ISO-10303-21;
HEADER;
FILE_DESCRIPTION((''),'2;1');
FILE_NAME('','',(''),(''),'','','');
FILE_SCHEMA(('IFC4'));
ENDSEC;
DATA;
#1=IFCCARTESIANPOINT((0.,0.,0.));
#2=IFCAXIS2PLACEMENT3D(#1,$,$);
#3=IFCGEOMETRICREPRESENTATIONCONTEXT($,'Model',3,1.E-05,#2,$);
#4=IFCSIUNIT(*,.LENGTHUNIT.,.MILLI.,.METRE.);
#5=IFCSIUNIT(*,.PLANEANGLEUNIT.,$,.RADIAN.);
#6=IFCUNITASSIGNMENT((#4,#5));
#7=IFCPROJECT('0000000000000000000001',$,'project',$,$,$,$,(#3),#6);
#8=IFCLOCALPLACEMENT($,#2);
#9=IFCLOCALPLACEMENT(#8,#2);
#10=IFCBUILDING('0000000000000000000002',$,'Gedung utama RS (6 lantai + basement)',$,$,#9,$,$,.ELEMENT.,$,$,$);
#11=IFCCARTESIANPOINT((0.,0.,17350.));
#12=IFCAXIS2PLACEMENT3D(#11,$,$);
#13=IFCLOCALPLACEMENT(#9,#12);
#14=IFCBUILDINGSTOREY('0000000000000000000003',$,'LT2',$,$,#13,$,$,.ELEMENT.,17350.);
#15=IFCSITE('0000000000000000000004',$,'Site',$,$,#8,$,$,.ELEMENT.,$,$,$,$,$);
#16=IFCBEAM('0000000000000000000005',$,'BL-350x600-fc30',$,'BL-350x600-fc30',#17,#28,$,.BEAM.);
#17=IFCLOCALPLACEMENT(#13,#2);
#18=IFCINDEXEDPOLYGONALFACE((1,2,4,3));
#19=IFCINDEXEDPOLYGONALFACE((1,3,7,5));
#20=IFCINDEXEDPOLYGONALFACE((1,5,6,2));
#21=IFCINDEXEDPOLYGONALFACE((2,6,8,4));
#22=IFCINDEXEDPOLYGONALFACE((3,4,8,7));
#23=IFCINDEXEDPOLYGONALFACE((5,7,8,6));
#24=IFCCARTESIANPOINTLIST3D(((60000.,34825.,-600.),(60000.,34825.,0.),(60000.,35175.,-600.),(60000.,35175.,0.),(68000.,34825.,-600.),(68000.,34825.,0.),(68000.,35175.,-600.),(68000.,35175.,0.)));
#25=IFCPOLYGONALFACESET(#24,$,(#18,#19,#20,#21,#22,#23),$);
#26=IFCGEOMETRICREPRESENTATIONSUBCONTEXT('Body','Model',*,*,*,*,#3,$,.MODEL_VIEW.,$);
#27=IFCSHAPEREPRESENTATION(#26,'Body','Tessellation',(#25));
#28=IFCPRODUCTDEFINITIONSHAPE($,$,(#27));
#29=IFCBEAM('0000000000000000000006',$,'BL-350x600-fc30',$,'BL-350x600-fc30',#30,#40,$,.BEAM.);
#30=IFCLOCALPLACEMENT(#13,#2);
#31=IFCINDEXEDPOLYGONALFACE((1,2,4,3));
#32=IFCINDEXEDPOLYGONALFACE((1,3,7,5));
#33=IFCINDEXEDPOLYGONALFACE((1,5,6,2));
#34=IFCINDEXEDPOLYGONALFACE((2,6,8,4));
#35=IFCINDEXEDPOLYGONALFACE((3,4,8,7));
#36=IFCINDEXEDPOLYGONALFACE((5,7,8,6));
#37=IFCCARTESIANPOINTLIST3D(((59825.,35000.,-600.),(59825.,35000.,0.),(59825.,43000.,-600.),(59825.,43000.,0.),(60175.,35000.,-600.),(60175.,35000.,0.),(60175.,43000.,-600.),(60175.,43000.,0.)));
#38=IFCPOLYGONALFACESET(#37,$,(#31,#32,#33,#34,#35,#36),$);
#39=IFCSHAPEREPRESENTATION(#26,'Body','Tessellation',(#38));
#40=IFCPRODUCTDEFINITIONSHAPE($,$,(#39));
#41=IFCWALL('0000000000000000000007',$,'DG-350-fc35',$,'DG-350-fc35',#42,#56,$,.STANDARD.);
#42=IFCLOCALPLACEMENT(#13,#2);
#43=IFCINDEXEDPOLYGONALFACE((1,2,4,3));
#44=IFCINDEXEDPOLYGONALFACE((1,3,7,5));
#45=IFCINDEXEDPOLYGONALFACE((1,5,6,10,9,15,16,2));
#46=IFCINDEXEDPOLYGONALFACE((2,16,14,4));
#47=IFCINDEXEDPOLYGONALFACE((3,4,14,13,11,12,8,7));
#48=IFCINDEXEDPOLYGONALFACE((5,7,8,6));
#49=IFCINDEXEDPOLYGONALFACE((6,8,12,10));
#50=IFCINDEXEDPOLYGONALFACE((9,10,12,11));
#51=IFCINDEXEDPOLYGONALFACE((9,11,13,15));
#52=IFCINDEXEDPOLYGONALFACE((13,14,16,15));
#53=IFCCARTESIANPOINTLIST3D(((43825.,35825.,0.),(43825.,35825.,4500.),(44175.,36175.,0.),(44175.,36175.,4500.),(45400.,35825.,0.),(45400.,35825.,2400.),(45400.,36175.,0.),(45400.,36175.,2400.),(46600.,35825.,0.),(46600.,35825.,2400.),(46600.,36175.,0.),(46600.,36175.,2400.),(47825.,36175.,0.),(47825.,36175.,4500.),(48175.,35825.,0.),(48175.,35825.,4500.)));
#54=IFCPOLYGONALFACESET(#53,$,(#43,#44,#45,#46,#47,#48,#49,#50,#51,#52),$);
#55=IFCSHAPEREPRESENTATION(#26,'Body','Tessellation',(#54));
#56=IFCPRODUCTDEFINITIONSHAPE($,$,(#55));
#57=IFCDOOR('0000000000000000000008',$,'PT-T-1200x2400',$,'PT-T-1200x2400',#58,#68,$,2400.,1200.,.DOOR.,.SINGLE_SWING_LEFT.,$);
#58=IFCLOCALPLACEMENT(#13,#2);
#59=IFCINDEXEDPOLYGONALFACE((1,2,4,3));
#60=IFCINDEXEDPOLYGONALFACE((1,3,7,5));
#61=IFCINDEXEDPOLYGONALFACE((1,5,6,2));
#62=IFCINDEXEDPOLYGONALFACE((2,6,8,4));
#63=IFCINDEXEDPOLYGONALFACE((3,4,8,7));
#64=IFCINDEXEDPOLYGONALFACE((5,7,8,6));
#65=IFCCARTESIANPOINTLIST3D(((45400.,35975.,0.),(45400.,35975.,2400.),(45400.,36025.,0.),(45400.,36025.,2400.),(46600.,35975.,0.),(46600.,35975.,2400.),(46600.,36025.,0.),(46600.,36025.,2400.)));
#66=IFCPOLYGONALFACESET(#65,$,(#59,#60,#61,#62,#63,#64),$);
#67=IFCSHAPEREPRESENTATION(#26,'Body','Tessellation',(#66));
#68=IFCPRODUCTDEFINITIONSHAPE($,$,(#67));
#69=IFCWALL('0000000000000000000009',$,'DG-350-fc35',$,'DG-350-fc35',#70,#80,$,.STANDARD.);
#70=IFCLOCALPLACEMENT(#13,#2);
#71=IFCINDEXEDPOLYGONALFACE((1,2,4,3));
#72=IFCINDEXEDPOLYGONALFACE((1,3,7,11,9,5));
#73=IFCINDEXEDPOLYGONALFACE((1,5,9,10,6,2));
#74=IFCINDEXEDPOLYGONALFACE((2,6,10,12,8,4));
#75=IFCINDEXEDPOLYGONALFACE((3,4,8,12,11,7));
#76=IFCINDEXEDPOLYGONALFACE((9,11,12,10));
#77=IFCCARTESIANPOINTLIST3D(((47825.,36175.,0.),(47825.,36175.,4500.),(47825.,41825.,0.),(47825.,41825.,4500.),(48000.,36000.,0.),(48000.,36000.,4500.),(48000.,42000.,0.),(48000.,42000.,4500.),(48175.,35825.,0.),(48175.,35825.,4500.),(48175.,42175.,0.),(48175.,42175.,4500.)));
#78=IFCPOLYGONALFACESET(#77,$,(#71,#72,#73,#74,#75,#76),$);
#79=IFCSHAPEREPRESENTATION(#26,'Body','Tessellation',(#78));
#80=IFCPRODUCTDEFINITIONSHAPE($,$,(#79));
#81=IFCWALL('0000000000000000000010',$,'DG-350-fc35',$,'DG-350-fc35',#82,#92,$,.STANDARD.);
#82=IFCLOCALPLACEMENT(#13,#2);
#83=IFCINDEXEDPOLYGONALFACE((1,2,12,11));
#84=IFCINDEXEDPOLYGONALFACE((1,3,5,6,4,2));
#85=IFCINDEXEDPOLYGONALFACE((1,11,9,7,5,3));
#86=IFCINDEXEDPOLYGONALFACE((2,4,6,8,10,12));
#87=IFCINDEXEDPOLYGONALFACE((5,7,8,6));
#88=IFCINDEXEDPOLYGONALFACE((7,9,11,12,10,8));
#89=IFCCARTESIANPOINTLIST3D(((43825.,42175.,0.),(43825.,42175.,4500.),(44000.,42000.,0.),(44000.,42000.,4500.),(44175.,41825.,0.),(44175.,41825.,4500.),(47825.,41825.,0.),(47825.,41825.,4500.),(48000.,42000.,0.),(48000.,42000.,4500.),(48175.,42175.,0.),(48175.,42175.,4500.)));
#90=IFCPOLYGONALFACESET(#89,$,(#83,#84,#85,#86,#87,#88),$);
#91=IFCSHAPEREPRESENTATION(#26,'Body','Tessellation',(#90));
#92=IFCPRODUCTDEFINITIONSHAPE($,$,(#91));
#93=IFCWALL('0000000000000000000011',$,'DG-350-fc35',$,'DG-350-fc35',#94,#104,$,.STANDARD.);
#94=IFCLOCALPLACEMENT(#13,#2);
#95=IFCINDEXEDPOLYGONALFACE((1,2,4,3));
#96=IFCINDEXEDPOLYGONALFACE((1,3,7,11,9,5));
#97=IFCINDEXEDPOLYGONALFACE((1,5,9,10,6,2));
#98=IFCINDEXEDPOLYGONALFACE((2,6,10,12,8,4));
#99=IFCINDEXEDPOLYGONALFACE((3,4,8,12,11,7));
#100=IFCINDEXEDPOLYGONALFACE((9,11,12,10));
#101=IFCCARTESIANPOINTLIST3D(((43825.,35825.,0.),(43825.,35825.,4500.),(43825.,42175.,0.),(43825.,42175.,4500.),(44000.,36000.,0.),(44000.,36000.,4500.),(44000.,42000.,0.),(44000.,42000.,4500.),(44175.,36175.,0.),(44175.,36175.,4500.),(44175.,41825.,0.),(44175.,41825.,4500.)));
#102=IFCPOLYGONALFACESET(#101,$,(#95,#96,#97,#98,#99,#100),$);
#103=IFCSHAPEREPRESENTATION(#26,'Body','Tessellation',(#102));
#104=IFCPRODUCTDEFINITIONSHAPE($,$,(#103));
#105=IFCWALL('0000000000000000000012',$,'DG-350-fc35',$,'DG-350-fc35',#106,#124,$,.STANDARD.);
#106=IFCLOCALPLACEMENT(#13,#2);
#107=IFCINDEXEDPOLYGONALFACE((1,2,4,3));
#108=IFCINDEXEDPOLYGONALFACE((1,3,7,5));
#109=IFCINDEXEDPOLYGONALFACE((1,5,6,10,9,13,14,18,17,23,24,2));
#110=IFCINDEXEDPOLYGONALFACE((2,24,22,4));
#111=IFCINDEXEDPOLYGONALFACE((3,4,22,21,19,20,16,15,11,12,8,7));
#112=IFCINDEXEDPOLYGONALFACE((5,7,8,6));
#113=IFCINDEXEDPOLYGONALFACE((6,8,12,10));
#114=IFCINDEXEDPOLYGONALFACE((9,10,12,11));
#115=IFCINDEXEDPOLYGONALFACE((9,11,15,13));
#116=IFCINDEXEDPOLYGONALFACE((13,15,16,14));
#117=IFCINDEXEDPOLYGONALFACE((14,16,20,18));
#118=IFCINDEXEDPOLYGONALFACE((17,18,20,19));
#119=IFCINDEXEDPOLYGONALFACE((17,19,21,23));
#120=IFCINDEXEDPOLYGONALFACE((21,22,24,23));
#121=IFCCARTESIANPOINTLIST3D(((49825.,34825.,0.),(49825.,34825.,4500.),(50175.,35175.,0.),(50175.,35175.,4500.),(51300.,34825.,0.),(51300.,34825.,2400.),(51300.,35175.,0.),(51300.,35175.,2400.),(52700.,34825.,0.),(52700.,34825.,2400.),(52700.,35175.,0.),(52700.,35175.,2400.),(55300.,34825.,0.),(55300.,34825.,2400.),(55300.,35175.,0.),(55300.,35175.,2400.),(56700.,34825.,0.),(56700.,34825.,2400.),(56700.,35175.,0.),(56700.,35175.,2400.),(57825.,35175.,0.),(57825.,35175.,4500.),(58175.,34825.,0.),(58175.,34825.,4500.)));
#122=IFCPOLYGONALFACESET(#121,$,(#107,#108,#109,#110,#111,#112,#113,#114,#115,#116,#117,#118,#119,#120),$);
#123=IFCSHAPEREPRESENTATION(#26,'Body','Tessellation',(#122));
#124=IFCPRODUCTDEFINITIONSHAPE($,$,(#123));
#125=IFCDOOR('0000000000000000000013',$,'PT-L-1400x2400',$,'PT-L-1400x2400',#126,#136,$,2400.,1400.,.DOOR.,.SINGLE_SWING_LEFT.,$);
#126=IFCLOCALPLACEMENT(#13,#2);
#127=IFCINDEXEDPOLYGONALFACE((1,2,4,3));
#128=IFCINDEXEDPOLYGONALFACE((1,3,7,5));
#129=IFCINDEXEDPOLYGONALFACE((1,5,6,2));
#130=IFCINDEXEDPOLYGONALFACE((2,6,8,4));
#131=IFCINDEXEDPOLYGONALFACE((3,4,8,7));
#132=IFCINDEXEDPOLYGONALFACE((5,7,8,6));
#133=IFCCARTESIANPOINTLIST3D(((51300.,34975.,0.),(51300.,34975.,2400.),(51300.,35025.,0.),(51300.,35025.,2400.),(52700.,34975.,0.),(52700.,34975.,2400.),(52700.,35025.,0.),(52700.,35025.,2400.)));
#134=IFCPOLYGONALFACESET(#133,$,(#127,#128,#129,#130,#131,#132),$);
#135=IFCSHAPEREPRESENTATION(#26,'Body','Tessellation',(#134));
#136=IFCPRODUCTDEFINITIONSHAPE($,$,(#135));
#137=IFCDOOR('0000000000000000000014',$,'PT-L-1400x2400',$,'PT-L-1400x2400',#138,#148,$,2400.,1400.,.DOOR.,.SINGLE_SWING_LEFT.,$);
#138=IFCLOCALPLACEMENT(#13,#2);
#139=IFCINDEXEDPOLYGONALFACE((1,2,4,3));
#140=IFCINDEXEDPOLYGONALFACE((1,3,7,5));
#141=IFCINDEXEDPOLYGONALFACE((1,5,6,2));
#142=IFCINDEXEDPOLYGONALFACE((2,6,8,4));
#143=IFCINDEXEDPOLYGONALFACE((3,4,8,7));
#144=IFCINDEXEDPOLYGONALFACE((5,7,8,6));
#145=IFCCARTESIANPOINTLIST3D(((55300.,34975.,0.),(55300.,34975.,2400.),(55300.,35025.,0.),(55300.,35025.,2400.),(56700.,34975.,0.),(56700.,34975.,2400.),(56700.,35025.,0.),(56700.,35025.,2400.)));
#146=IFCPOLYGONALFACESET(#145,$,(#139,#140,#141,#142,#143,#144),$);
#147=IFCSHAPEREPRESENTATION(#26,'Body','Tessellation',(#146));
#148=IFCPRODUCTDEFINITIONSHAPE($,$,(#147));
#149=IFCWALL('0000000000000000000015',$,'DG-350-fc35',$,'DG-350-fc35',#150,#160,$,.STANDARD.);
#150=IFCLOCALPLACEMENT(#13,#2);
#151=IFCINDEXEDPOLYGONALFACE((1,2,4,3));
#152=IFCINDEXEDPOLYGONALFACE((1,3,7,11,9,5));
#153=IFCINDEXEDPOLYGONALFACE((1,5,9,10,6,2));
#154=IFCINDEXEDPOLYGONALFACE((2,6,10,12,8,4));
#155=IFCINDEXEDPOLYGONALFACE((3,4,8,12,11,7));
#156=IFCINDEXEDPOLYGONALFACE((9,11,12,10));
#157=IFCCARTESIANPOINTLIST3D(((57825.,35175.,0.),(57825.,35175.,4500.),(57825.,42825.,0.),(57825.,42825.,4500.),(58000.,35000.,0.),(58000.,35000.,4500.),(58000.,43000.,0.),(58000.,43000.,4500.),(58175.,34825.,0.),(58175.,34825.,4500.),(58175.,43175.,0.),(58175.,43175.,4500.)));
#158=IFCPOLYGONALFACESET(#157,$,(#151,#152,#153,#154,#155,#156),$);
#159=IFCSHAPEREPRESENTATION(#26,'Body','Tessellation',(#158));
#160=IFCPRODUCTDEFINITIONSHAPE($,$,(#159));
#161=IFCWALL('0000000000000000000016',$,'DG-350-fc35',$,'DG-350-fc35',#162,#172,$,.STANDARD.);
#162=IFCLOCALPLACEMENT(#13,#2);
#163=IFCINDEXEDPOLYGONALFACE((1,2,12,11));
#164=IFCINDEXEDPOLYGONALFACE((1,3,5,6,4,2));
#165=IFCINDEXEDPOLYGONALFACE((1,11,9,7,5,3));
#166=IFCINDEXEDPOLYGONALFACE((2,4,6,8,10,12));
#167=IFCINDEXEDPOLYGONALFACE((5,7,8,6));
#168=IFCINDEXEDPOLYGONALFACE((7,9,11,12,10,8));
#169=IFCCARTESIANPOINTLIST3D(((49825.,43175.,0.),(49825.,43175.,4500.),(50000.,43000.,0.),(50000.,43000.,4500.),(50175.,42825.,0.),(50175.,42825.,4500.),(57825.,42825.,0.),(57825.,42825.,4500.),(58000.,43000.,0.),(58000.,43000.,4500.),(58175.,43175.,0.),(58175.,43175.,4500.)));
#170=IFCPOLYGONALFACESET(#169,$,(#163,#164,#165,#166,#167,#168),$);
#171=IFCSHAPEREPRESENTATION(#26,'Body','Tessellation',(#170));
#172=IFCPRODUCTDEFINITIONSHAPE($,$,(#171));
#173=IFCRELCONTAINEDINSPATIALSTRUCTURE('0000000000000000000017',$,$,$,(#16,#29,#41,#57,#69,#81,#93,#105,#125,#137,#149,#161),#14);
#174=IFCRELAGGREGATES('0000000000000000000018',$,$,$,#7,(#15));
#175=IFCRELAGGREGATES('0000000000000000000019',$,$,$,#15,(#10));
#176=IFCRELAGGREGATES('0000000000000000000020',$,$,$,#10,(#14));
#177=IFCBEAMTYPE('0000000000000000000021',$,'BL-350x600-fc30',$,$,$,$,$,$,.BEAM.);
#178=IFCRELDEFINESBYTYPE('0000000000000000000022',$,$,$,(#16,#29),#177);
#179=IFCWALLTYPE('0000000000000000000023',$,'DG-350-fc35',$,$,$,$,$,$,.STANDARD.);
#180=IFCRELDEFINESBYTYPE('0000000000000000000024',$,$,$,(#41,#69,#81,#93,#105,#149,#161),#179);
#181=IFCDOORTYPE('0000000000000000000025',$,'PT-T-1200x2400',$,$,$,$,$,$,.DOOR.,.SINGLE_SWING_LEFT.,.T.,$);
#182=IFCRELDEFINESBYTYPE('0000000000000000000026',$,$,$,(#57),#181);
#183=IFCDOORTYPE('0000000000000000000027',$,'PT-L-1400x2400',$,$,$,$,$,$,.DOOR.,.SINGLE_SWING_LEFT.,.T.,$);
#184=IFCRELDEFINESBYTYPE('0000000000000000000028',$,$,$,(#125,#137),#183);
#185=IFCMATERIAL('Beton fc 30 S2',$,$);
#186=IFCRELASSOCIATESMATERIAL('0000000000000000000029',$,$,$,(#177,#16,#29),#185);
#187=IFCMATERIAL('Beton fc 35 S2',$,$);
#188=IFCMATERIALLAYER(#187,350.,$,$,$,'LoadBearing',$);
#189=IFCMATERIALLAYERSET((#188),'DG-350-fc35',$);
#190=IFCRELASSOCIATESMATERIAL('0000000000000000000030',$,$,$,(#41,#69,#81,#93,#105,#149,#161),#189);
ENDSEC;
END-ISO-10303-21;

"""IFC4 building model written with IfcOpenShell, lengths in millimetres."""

from ifc_helpers import new_model, si_unit, frame, frame_2d, origin, origin_2d, place, context, subcontext, project, spatial, polyline, rectangle, outline, extrude, material, layer, layer_set, layer_usage, material_profile, profile_set, profile_usage, type_object, element, fill, save


model = new_model("IFC4")

# Units and contexts
model_context = context("Model", 3, precision=1e-05, world=origin())
body_context = subcontext(model_context, "Body", "Model", "MODEL_VIEW")
ifc_project = project(units=[si_unit("LENGTHUNIT", "METRE", prefix="MILLI"), si_unit("PLANEANGLEUNIT", "RADIAN")], contexts=[model_context])

# Site, building, storey
site_placement = place(None, origin())
site = spatial("IfcSite", under=ifc_project, at=site_placement, Name="Site", CompositionType="ELEMENT")
building_placement = place(site_placement, origin())
building = spatial("IfcBuilding", under=site, at=building_placement, Name="Gedung utama RS (6 lantai + basement)", CompositionType="ELEMENT")
storey_placement = place(building_placement, frame((0.0, 0.0, 17350.0)))
storey = spatial("IfcBuildingStorey", under=building, at=storey_placement, Name="LT2", CompositionType="ELEMENT", Elevation=17350.0)

# Beams
ifc_material_1 = material(Name="Beton fc 30 S2")
ifc_material_profile_1 = material_profile(ifc_material_1, rectangle(XDim=350.0, YDim=600.0, at=origin_2d()), Name="BL-350x600-fc30")
ifc_profile_set_1 = profile_set([ifc_material_profile_1], Name="BL-350x600-fc30")
ifc_profile_usage_1 = profile_usage(ifc_profile_set_1, cardinal=8)
beam_type = type_object("IfcBeamType", Name="BL-350x600-fc30", PredefinedType="BEAM", material=ifc_profile_set_1)
beam_1_placement = place(storey_placement, frame((60000.0, 35000.0, -300.0)))
element("IfcBeam", 1, at=beam_1_placement, inside=storey, type_object=beam_type, material=ifc_profile_usage_1, Name="BL-350x600-fc30", ObjectType="BL-350x600-fc30", PredefinedType="BEAM", context=body_context, shape_type="SweptSolid", body=[
    extrude(rectangle(XDim=350.0, YDim=600.0, at=origin_2d()), frame((0.0, 0.0, 0.0), z_axis=(1.0, 0.0, 0.0), x_axis=(0.0, 1.0, 0.0)), (0.0, 0.0, 1.0), 8000.0),
])
beam_2_placement = place(storey_placement, frame((60000.0, 35000.0, -300.0)))
element("IfcBeam", 2, at=beam_2_placement, inside=storey, type_object=beam_type, material=ifc_profile_usage_1, Name="BL-350x600-fc30", ObjectType="BL-350x600-fc30", PredefinedType="BEAM", context=body_context, shape_type="SweptSolid", body=[
    extrude(rectangle(XDim=350.0, YDim=600.0, at=origin_2d()), frame((0.0, 0.0, 0.0), z_axis=(0.0, 1.0, 0.0), x_axis=(-1.0, 0.0, 0.0)), (0.0, 0.0, 1.0), 8000.0),
])

# Wall, opening, door
ifc_material_2 = material(Name="Beton fc 35 S2")
ifc_layer = layer(ifc_material_2, 350.0, Category="LoadBearing")
ifc_layer_set = layer_set([ifc_layer], Name="DG-350-fc35")
ifc_layer_usage = layer_usage(ifc_layer_set, "AXIS2", "NEGATIVE", 175.0)
wall_type = type_object("IfcWallType", Name="DG-350-fc35", PredefinedType="STANDARD")
wall_1_placement = place(storey_placement, frame((44000.0, 36000.0, 0.0), z_axis=(0.0, 0.0, 1.0), x_axis=(1.0, 0.0, 0.0)))
wall_1 = element("IfcWall", 3, at=wall_1_placement, inside=storey, type_object=wall_type, material=ifc_layer_usage, Name="DG-350-fc35", ObjectType="DG-350-fc35", PredefinedType="STANDARD", context=body_context, shape_type="SweptSolid", body=[
    extrude(outline(polyline([(-175.0, -175.0), (0.0, 0.0), (175.0, 175.0), (3825.0, 175.0), (4000.0, 0.0), (4175.0, -175.0), (-175.0, -175.0)])), origin(), (0.0, 0.0, 1.0), 4500.0),
])
opening_1_placement = place(wall_1_placement, frame((1400.0, 0.0, 0.0), z_axis=(0.0, 0.0, 1.0), x_axis=(1.0, 0.0, 0.0)))
opening_1 = element("IfcOpeningElement", 4, at=opening_1_placement, cuts=wall_1, PredefinedType="OPENING", context=body_context, shape_type="SweptSolid", body=[
    extrude(rectangle(XDim=1200.0, YDim=370.0, at=frame_2d((600.0, 0.0))), origin(), (0.0, 0.0, 1.0), 2400.0),
])
door_type_1 = type_object("IfcDoorType", Name="PT-T-1200x2400", OperationType="SINGLE_SWING_LEFT", ParameterTakesPrecedence=True, PredefinedType="DOOR")
door_1_placement = place(opening_1_placement, origin())
door_1 = element("IfcDoor", 5, at=door_1_placement, inside=storey, type_object=door_type_1, Name="PT-T-1200x2400", ObjectType="PT-T-1200x2400", OperationType="SINGLE_SWING_LEFT", OverallHeight=2400.0, OverallWidth=1200.0, PredefinedType="DOOR", context=body_context, shape_type="SweptSolid", body=[
    extrude(rectangle(XDim=1200.0, YDim=50.0, at=frame_2d((600.0, 0.0))), origin(), (0.0, 0.0, 1.0), 2400.0),
])
fill(opening_1, door_1)

# Walls
wall_2_placement = place(storey_placement, frame((48000.0, 36000.0, 0.0), z_axis=(0.0, 0.0, 1.0), x_axis=(0.0, 1.0, 0.0)))
element("IfcWall", 6, at=wall_2_placement, inside=storey, type_object=wall_type, material=ifc_layer_usage, Name="DG-350-fc35", ObjectType="DG-350-fc35", PredefinedType="STANDARD", context=body_context, shape_type="SweptSolid", body=[
    extrude(outline(polyline([(-175.0, -175.0), (0.0, 0.0), (175.0, 175.0), (5825.0, 175.0), (6000.0, 0.0), (6175.0, -175.0), (-175.0, -175.0)])), origin(), (0.0, 0.0, 1.0), 4500.0),
])
wall_3_placement = place(storey_placement, frame((48000.0, 42000.0, 0.0), z_axis=(0.0, 0.0, 1.0), x_axis=(-1.0, 0.0, 0.0)))
element("IfcWall", 7, at=wall_3_placement, inside=storey, type_object=wall_type, material=ifc_layer_usage, Name="DG-350-fc35", ObjectType="DG-350-fc35", PredefinedType="STANDARD", context=body_context, shape_type="SweptSolid", body=[
    extrude(outline(polyline([(-175.0, -175.0), (0.0, 0.0), (175.0, 175.0), (3825.0, 175.0), (4000.0, 0.0), (4175.0, -175.0), (-175.0, -175.0)])), origin(), (0.0, 0.0, 1.0), 4500.0),
])
wall_4_placement = place(storey_placement, frame((44000.0, 42000.0, 0.0), z_axis=(0.0, 0.0, 1.0), x_axis=(0.0, -1.0, 0.0)))
element("IfcWall", 8, at=wall_4_placement, inside=storey, type_object=wall_type, material=ifc_layer_usage, Name="DG-350-fc35", ObjectType="DG-350-fc35", PredefinedType="STANDARD", context=body_context, shape_type="SweptSolid", body=[
    extrude(outline(polyline([(-175.0, -175.0), (0.0, 0.0), (175.0, 175.0), (5825.0, 175.0), (6000.0, 0.0), (6175.0, -175.0), (-175.0, -175.0)])), origin(), (0.0, 0.0, 1.0), 4500.0),
])

# Wall, openings, doors
wall_5_placement = place(storey_placement, frame((50000.0, 35000.0, 0.0), z_axis=(0.0, 0.0, 1.0), x_axis=(1.0, 0.0, 0.0)))
wall_5 = element("IfcWall", 9, at=wall_5_placement, inside=storey, type_object=wall_type, material=ifc_layer_usage, Name="DG-350-fc35", ObjectType="DG-350-fc35", PredefinedType="STANDARD", context=body_context, shape_type="SweptSolid", body=[
    extrude(outline(polyline([(-175.0, -175.0), (0.0, 0.0), (175.0, 175.0), (7825.0, 175.0), (8000.0, 0.0), (8175.0, -175.0), (-175.0, -175.0)])), origin(), (0.0, 0.0, 1.0), 4500.0),
])
opening_2_placement = place(wall_5_placement, frame((1300.0, 0.0, 0.0), z_axis=(0.0, 0.0, 1.0), x_axis=(1.0, 0.0, 0.0)))
opening_2 = element("IfcOpeningElement", 10, at=opening_2_placement, cuts=wall_5, PredefinedType="OPENING", context=body_context, shape_type="SweptSolid", body=[
    extrude(rectangle(XDim=1400.0, YDim=370.0, at=frame_2d((700.0, 0.0))), origin(), (0.0, 0.0, 1.0), 2400.0),
])
opening_3_placement = place(wall_5_placement, frame((5300.0, 0.0, 0.0), z_axis=(0.0, 0.0, 1.0), x_axis=(1.0, 0.0, 0.0)))
opening_3 = element("IfcOpeningElement", 11, at=opening_3_placement, cuts=wall_5, PredefinedType="OPENING", context=body_context, shape_type="SweptSolid", body=[
    extrude(rectangle(XDim=1400.0, YDim=370.0, at=frame_2d((700.0, 0.0))), origin(), (0.0, 0.0, 1.0), 2400.0),
])
door_type_2 = type_object("IfcDoorType", Name="PT-L-1400x2400", OperationType="SINGLE_SWING_LEFT", ParameterTakesPrecedence=True, PredefinedType="DOOR")
door_2_placement = place(opening_2_placement, origin())
door_2 = element("IfcDoor", 12, at=door_2_placement, inside=storey, type_object=door_type_2, Name="PT-L-1400x2400", ObjectType="PT-L-1400x2400", OperationType="SINGLE_SWING_LEFT", OverallHeight=2400.0, OverallWidth=1400.0, PredefinedType="DOOR", context=body_context, shape_type="SweptSolid", body=[
    extrude(rectangle(XDim=1400.0, YDim=50.0, at=frame_2d((700.0, 0.0))), origin(), (0.0, 0.0, 1.0), 2400.0),
])
fill(opening_2, door_2)
door_3_placement = place(opening_3_placement, origin())
door_3 = element("IfcDoor", 13, at=door_3_placement, inside=storey, type_object=door_type_2, Name="PT-L-1400x2400", ObjectType="PT-L-1400x2400", OperationType="SINGLE_SWING_LEFT", OverallHeight=2400.0, OverallWidth=1400.0, PredefinedType="DOOR", context=body_context, shape_type="SweptSolid", body=[
    extrude(rectangle(XDim=1400.0, YDim=50.0, at=frame_2d((700.0, 0.0))), origin(), (0.0, 0.0, 1.0), 2400.0),
])
fill(opening_3, door_3)

# Walls
for number, where, z_axis, x_axis, name in (
    (14, (58000.0, 35000.0, 0.0), (0.0, 0.0, 1.0), (0.0, 1.0, 0.0), "DG-350-fc35"),
    (15, (58000.0, 43000.0, 0.0), (0.0, 0.0, 1.0), (-1.0, 0.0, 0.0), "DG-350-fc35"),
):
    element("IfcWall", number, at=place(storey_placement, frame(where, z_axis=z_axis, x_axis=x_axis)), inside=storey, type_object=wall_type, material=ifc_layer_usage, Name=name, ObjectType="DG-350-fc35", PredefinedType="STANDARD", context=body_context, shape_type="SweptSolid", body=[
        extrude(outline(polyline([(-175.0, -175.0), (0.0, 0.0), (175.0, 175.0), (7825.0, 175.0), (8000.0, 0.0), (8175.0, -175.0), (-175.0, -175.0)])), origin(), (0.0, 0.0, 1.0), 4500.0),
    ])

save(model, "model.ifc")
